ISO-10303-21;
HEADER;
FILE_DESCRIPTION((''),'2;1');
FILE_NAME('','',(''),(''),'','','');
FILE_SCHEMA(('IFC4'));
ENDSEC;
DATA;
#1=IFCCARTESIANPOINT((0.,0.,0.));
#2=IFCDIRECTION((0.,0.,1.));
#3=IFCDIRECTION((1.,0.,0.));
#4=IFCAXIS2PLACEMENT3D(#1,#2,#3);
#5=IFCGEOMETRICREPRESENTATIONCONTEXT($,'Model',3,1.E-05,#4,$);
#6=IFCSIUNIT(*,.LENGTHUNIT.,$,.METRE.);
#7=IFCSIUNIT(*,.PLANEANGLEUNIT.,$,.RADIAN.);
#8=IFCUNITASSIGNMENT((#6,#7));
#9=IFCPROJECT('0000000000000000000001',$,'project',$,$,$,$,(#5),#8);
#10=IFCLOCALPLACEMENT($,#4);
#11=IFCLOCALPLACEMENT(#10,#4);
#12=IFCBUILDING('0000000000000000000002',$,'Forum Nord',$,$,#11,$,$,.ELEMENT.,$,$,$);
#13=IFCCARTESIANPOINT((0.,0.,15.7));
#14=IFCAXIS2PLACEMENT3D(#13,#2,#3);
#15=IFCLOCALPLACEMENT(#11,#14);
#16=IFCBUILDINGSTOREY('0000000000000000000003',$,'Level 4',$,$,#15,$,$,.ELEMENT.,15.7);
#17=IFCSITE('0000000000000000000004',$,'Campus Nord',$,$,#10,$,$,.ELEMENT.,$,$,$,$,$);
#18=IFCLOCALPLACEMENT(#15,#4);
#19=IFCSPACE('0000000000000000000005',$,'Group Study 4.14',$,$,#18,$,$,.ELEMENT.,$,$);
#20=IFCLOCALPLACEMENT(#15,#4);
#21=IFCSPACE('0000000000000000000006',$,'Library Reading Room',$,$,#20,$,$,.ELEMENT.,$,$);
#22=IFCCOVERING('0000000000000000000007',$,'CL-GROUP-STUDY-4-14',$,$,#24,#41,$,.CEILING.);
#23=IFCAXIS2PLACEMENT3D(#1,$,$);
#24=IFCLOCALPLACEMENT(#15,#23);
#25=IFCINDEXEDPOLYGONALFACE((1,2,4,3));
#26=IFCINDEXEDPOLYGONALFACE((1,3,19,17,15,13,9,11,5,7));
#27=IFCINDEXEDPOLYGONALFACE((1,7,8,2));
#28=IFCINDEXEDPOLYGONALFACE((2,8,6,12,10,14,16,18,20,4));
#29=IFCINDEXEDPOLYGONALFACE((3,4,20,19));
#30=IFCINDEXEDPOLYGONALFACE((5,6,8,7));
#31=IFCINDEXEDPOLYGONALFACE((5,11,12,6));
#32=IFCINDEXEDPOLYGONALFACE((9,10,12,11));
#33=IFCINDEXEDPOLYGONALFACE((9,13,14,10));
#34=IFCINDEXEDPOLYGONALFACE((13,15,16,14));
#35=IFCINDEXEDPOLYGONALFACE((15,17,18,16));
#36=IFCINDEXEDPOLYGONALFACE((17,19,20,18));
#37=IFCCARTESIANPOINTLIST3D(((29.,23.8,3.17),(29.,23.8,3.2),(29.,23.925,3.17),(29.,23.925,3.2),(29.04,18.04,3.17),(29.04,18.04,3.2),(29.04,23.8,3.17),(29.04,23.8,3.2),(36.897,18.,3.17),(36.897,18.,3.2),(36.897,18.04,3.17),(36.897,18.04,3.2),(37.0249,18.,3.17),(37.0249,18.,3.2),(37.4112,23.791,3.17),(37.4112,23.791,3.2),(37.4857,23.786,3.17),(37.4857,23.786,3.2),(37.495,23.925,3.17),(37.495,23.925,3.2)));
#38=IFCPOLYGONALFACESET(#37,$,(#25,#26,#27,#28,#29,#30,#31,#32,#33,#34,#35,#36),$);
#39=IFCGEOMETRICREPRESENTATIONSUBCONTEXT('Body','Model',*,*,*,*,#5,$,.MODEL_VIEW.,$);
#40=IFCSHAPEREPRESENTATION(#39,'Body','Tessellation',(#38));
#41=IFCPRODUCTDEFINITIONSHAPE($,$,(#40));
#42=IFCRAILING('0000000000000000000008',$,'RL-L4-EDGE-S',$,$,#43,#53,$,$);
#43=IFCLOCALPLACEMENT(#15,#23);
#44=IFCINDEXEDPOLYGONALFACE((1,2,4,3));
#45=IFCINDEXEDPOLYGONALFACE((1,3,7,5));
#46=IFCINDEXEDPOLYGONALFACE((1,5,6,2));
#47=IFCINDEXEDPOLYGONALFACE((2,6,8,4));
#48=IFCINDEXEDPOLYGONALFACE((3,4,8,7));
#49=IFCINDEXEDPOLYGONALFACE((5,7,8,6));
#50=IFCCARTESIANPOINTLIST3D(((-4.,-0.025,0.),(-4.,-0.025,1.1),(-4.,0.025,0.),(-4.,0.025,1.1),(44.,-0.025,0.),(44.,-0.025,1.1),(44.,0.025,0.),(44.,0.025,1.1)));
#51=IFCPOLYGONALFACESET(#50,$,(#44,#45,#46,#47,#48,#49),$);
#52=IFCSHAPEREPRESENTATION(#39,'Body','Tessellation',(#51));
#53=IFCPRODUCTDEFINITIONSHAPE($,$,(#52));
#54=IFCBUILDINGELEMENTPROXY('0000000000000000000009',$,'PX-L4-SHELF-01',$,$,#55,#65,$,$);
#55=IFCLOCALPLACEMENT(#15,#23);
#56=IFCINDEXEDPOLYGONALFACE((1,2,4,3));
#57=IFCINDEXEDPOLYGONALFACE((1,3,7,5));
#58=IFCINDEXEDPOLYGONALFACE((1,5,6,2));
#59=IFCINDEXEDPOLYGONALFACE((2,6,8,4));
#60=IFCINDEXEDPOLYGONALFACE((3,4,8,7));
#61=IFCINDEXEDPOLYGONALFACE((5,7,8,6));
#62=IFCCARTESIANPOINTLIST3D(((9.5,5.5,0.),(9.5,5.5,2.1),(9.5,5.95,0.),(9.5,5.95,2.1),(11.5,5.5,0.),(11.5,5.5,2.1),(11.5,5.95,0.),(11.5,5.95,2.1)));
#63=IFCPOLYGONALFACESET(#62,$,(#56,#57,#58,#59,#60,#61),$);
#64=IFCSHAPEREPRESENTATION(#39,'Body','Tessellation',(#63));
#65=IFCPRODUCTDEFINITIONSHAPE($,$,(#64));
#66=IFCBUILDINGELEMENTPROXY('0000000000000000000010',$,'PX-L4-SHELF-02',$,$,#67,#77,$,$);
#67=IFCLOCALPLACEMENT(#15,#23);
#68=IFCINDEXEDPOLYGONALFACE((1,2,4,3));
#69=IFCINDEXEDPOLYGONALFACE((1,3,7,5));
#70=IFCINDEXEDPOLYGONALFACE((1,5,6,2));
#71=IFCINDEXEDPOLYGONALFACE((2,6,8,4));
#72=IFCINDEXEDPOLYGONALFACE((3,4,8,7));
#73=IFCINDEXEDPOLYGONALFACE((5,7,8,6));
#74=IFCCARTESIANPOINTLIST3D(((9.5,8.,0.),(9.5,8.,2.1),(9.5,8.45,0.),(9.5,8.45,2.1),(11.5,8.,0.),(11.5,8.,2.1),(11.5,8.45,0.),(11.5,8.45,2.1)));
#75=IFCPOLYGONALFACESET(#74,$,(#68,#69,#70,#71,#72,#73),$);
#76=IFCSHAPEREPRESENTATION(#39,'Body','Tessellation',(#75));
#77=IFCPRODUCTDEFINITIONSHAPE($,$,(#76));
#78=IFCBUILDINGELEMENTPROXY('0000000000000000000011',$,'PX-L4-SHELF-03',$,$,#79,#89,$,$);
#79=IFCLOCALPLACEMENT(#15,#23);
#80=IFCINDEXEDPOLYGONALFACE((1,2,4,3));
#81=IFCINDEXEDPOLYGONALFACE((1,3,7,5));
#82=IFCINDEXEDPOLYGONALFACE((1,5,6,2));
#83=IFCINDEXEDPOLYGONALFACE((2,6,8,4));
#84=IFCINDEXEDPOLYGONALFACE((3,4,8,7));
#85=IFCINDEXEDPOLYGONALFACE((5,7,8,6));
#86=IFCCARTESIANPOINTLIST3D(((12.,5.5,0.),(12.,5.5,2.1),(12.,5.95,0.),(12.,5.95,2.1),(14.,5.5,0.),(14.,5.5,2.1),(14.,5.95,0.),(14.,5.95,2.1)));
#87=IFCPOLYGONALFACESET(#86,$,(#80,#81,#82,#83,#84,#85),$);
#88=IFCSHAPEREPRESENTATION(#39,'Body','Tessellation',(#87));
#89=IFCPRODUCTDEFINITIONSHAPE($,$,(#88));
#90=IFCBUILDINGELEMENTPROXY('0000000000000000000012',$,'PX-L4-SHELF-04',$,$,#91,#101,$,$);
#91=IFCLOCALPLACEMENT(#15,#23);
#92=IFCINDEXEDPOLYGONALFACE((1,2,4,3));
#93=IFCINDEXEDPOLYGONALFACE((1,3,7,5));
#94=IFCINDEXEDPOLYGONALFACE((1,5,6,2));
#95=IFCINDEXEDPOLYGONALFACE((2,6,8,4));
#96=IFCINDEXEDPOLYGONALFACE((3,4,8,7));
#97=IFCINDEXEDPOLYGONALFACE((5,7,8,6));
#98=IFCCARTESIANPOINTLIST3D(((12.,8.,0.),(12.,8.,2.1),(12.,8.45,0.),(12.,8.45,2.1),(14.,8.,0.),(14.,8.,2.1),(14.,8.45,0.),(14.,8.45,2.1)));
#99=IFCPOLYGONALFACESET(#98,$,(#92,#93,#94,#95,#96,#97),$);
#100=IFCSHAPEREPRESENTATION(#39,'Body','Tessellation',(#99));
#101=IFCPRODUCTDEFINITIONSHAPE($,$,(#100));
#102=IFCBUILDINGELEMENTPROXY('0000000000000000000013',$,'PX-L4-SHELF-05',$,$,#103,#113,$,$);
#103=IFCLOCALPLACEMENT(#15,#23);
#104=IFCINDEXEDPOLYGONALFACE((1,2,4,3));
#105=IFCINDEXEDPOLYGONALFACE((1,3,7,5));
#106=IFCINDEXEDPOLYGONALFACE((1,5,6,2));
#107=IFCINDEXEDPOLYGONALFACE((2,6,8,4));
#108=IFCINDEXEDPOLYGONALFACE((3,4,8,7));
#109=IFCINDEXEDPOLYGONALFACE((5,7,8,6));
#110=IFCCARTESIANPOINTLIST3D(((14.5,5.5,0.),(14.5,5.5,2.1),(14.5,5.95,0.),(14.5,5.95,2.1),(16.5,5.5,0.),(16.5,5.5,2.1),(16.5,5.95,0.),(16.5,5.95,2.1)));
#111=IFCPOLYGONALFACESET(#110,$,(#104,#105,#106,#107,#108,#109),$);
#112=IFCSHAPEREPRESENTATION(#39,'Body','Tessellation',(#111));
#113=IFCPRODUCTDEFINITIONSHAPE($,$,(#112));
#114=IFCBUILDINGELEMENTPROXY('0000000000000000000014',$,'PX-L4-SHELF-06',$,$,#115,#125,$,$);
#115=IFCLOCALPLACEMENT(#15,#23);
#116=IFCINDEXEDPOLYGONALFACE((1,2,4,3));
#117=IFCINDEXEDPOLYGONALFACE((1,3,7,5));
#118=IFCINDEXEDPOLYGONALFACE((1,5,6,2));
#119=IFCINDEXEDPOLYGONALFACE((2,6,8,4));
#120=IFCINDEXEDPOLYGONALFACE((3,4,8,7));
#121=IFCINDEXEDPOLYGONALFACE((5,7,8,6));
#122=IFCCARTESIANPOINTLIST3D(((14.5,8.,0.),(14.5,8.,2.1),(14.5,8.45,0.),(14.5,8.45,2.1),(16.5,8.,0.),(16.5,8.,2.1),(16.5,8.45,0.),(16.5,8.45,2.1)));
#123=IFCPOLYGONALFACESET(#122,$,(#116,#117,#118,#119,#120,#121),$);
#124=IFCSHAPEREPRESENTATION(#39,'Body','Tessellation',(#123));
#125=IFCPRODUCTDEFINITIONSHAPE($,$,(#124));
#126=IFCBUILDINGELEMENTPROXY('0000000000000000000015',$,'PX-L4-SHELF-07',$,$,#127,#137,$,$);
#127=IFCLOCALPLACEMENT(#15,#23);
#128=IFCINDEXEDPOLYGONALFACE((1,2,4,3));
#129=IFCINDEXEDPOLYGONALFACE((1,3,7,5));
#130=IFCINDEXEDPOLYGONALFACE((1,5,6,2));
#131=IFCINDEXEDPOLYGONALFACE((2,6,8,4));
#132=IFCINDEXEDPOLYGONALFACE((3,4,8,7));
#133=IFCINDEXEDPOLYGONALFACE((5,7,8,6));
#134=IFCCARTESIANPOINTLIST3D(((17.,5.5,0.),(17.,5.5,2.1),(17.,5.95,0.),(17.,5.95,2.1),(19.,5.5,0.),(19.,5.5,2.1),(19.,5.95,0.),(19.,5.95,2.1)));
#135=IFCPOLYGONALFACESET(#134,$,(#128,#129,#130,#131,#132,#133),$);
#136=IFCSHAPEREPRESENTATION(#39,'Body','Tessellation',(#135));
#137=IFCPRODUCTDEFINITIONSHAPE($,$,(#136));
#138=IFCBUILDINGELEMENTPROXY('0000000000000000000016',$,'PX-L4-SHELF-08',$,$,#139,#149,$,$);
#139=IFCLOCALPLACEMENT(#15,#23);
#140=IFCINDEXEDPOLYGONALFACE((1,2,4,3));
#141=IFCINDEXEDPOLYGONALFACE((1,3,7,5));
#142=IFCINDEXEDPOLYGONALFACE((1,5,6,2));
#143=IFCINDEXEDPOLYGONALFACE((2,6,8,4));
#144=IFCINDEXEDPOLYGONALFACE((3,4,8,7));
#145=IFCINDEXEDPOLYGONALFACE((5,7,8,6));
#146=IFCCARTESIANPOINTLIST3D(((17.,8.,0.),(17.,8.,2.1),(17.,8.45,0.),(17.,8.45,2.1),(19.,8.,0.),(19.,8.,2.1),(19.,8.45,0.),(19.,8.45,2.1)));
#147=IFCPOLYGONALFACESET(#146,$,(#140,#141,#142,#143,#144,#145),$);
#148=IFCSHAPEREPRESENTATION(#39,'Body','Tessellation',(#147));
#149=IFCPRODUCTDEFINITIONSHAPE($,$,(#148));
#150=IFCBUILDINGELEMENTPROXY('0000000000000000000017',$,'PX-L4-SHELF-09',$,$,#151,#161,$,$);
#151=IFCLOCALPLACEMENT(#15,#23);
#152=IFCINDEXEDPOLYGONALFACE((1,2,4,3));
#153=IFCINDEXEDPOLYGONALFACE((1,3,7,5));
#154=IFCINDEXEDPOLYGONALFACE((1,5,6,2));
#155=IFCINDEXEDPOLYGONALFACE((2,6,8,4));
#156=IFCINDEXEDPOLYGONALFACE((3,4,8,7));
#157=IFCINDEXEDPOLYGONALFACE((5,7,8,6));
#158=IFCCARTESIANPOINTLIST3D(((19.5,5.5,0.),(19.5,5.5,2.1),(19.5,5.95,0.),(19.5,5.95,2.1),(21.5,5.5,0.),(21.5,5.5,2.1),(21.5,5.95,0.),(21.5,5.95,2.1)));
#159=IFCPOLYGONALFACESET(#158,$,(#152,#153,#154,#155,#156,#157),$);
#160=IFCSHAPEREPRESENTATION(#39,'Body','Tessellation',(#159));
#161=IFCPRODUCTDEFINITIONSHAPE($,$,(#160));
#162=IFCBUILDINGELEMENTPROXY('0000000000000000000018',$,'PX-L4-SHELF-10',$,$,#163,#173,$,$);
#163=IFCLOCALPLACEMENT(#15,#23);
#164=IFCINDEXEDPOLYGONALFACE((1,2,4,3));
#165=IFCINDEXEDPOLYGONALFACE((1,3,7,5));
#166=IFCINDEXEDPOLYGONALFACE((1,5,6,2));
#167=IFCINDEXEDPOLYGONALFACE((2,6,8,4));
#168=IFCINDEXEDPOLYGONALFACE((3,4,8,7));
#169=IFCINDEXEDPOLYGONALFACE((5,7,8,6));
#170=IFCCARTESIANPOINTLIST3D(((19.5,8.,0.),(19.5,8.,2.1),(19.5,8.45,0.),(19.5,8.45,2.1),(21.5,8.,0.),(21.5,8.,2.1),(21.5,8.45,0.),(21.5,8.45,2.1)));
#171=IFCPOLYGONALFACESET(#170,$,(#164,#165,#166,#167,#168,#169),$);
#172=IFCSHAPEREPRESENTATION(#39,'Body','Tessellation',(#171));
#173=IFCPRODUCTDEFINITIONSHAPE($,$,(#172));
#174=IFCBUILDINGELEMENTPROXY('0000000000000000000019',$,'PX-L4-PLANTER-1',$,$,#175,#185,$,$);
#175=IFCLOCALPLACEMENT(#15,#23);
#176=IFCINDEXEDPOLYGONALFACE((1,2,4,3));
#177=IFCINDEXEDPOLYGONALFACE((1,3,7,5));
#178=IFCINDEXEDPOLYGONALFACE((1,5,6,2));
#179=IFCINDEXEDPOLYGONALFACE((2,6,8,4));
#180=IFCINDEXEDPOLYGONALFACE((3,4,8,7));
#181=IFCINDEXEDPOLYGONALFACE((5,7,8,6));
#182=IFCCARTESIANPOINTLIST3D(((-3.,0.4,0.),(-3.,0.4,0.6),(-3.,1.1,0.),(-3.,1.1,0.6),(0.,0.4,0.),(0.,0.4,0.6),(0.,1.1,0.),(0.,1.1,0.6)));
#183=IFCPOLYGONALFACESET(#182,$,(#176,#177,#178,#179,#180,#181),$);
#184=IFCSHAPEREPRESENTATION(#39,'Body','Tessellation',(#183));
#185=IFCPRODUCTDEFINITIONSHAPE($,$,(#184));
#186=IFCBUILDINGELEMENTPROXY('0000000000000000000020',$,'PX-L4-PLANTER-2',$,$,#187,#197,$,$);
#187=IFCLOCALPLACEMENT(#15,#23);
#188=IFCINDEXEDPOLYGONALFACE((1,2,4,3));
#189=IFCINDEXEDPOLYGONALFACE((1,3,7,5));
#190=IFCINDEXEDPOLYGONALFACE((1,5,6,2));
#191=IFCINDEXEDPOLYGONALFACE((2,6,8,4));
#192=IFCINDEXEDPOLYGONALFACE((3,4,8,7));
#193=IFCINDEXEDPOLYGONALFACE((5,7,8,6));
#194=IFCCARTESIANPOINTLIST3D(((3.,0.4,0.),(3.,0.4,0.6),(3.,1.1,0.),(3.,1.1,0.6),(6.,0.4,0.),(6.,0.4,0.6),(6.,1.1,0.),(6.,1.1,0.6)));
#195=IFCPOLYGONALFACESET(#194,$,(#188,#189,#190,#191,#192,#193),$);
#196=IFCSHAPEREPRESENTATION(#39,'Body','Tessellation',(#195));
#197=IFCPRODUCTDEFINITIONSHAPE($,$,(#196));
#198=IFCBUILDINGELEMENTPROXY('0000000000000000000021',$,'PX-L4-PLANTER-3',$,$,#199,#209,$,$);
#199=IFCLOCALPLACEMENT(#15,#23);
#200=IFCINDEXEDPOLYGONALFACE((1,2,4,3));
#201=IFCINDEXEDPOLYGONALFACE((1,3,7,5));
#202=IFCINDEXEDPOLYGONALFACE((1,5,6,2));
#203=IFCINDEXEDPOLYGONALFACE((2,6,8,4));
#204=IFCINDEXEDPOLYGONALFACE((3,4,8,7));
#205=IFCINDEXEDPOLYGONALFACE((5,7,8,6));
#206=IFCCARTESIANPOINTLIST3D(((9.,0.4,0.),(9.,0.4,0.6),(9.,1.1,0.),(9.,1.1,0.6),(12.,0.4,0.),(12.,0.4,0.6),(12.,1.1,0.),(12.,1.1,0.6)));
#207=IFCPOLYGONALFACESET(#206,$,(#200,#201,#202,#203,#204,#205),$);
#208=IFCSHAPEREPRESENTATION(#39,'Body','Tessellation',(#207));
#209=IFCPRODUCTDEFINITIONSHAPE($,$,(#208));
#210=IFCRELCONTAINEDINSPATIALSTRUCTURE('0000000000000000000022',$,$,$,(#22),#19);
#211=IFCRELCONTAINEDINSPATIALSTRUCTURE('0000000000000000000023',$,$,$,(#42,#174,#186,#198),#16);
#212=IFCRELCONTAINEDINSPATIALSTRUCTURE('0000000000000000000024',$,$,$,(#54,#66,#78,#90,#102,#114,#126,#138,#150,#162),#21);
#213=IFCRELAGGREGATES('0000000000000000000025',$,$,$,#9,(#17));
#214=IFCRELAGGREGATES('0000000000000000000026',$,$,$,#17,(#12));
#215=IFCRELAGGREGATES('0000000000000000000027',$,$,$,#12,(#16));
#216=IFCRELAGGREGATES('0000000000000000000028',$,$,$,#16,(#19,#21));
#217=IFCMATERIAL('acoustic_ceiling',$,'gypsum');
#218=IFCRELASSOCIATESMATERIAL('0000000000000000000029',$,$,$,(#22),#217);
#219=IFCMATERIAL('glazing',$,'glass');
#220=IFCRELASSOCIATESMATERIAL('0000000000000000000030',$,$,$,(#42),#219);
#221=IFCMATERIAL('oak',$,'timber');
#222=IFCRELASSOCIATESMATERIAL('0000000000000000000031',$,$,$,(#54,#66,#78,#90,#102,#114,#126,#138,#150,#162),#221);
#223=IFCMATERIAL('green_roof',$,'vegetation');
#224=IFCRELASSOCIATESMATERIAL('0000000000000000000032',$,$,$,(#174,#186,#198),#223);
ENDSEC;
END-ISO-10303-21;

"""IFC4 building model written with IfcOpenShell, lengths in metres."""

from ifc_helpers import new_model, si_unit, frame, frame_2d, origin_with_axes, place, context, subcontext, project, spatial, polyline, rectangle, outline, extrude, material, element, save


model = new_model("IFC4")

# Units and contexts
model_context = context("Model", 3, precision=1e-05, world=origin_with_axes())
body_context = subcontext(model_context, "Body", "Model", "MODEL_VIEW")
ifc_project = project(units=[si_unit("LENGTHUNIT", "METRE"), si_unit("PLANEANGLEUNIT", "RADIAN")], contexts=[model_context])

# Site, building, storey
site_placement = place(None, origin_with_axes())
site = spatial("IfcSite", under=ifc_project, at=site_placement, Name="Campus Nord", CompositionType="ELEMENT")
building_placement = place(site_placement, origin_with_axes())
building = spatial("IfcBuilding", under=site, at=building_placement, Name="Forum Nord", CompositionType="ELEMENT")
storey_placement = place(building_placement, frame((0.0, 0.0, 15.7), z_axis=(0.0, 0.0, 1.0), x_axis=(1.0, 0.0, 0.0)))
storey = spatial("IfcBuildingStorey", under=building, at=storey_placement, Name="Level 4", CompositionType="ELEMENT", Elevation=15.7)

# Shared definitions
ifc_material_1 = material(Name="acoustic_ceiling", Category="gypsum")

# Shared definitions
space_1_placement = place(storey_placement, origin_with_axes())
space_1 = spatial("IfcSpace", under=storey, at=space_1_placement, Name="Group Study 4.14", CompositionType="ELEMENT")

# Covering
covering_1_placement = place(storey_placement, frame((0.0, 0.0, 3.17), z_axis=(0.0, 0.0, 1.0), x_axis=(1.0, 0.0, 0.0)))
element("IfcCovering", 1, at=covering_1_placement, inside=space_1, material=ifc_material_1, Name="CL-GROUP-STUDY-4-14", PredefinedType="CEILING", context=body_context, shape_type="SweptSolid", body=[
    extrude(outline(polyline([(29.0, 23.925), (29.0, 23.8), (29.04, 23.8), (29.04, 18.04), (36.897, 18.04), (36.897, 18.0), (37.0249, 18.0), (37.4112, 23.791), (37.4857, 23.786), (37.495, 23.925), (29.0, 23.925)])), origin_with_axes(), (0.0, 0.0, 1.0), 0.03),
])

# Railing
ifc_material_2 = material(Name="glazing", Category="glass")
railing_placement = place(storey_placement, frame((-4.0, 0.0, 0.0), z_axis=(0.0, 0.0, 1.0), x_axis=(1.0, 0.0, 0.0)))
element("IfcRailing", 2, at=railing_placement, inside=storey, material=ifc_material_2, Name="RL-L4-EDGE-S", context=body_context, shape_type="SweptSolid", body=[
    extrude(rectangle(XDim=48.0, YDim=0.05, at=frame_2d((24.0, 0.0), x_axis=(1.0, 0.0))), origin_with_axes(), (0.0, 0.0, 1.0), 1.1),
])

# Shared definitions
space_2_placement = place(storey_placement, origin_with_axes())
space_2 = spatial("IfcSpace", under=storey, at=space_2_placement, Name="Library Reading Room", CompositionType="ELEMENT")

# Building element proxies
ifc_material_3 = material(Name="oak", Category="timber")
proxy_1_placement = place(storey_placement, origin_with_axes())
element("IfcBuildingElementProxy", 3, at=proxy_1_placement, inside=space_2, material=ifc_material_3, Name="PX-L4-SHELF-01", context=body_context, shape_type="SweptSolid", body=[
    extrude(outline(polyline([(9.5, 5.5), (11.5, 5.5), (11.5, 5.95), (9.5, 5.95), (9.5, 5.5)])), origin_with_axes(), (0.0, 0.0, 1.0), 2.1),
])
proxy_2_placement = place(storey_placement, origin_with_axes())
element("IfcBuildingElementProxy", 4, at=proxy_2_placement, inside=space_2, material=ifc_material_3, Name="PX-L4-SHELF-02", context=body_context, shape_type="SweptSolid", body=[
    extrude(outline(polyline([(9.5, 8.0), (11.5, 8.0), (11.5, 8.45), (9.5, 8.45), (9.5, 8.0)])), origin_with_axes(), (0.0, 0.0, 1.0), 2.1),
])
proxy_3_placement = place(storey_placement, origin_with_axes())
element("IfcBuildingElementProxy", 5, at=proxy_3_placement, inside=space_2, material=ifc_material_3, Name="PX-L4-SHELF-03", context=body_context, shape_type="SweptSolid", body=[
    extrude(outline(polyline([(12.0, 5.5), (14.0, 5.5), (14.0, 5.95), (12.0, 5.95), (12.0, 5.5)])), origin_with_axes(), (0.0, 0.0, 1.0), 2.1),
])
proxy_4_placement = place(storey_placement, origin_with_axes())
element("IfcBuildingElementProxy", 6, at=proxy_4_placement, inside=space_2, material=ifc_material_3, Name="PX-L4-SHELF-04", context=body_context, shape_type="SweptSolid", body=[
    extrude(outline(polyline([(12.0, 8.0), (14.0, 8.0), (14.0, 8.45), (12.0, 8.45), (12.0, 8.0)])), origin_with_axes(), (0.0, 0.0, 1.0), 2.1),
])
proxy_5_placement = place(storey_placement, origin_with_axes())
element("IfcBuildingElementProxy", 7, at=proxy_5_placement, inside=space_2, material=ifc_material_3, Name="PX-L4-SHELF-05", context=body_context, shape_type="SweptSolid", body=[
    extrude(outline(polyline([(14.5, 5.5), (16.5, 5.5), (16.5, 5.95), (14.5, 5.95), (14.5, 5.5)])), origin_with_axes(), (0.0, 0.0, 1.0), 2.1),
])
proxy_6_placement = place(storey_placement, origin_with_axes())
element("IfcBuildingElementProxy", 8, at=proxy_6_placement, inside=space_2, material=ifc_material_3, Name="PX-L4-SHELF-06", context=body_context, shape_type="SweptSolid", body=[
    extrude(outline(polyline([(14.5, 8.0), (16.5, 8.0), (16.5, 8.45), (14.5, 8.45), (14.5, 8.0)])), origin_with_axes(), (0.0, 0.0, 1.0), 2.1),
])
proxy_7_placement = place(storey_placement, origin_with_axes())
element("IfcBuildingElementProxy", 9, at=proxy_7_placement, inside=space_2, material=ifc_material_3, Name="PX-L4-SHELF-07", context=body_context, shape_type="SweptSolid", body=[
    extrude(outline(polyline([(17.0, 5.5), (19.0, 5.5), (19.0, 5.95), (17.0, 5.95), (17.0, 5.5)])), origin_with_axes(), (0.0, 0.0, 1.0), 2.1),
])
proxy_8_placement = place(storey_placement, origin_with_axes())
element("IfcBuildingElementProxy", 10, at=proxy_8_placement, inside=space_2, material=ifc_material_3, Name="PX-L4-SHELF-08", context=body_context, shape_type="SweptSolid", body=[
    extrude(outline(polyline([(17.0, 8.0), (19.0, 8.0), (19.0, 8.45), (17.0, 8.45), (17.0, 8.0)])), origin_with_axes(), (0.0, 0.0, 1.0), 2.1),
])
proxy_9_placement = place(storey_placement, origin_with_axes())
element("IfcBuildingElementProxy", 11, at=proxy_9_placement, inside=space_2, material=ifc_material_3, Name="PX-L4-SHELF-09", context=body_context, shape_type="SweptSolid", body=[
    extrude(outline(polyline([(19.5, 5.5), (21.5, 5.5), (21.5, 5.95), (19.5, 5.95), (19.5, 5.5)])), origin_with_axes(), (0.0, 0.0, 1.0), 2.1),
])
proxy_10_placement = place(storey_placement, origin_with_axes())
element("IfcBuildingElementProxy", 12, at=proxy_10_placement, inside=space_2, material=ifc_material_3, Name="PX-L4-SHELF-10", context=body_context, shape_type="SweptSolid", body=[
    extrude(outline(polyline([(19.5, 8.0), (21.5, 8.0), (21.5, 8.45), (19.5, 8.45), (19.5, 8.0)])), origin_with_axes(), (0.0, 0.0, 1.0), 2.1),
])
ifc_material_4 = material(Name="green_roof", Category="vegetation")
proxy_11_placement = place(storey_placement, origin_with_axes())
element("IfcBuildingElementProxy", 13, at=proxy_11_placement, inside=storey, material=ifc_material_4, Name="PX-L4-PLANTER-1", context=body_context, shape_type="SweptSolid", body=[
    extrude(outline(polyline([(-3.0, 0.4), (0.0, 0.4), (0.0, 1.1), (-3.0, 1.1), (-3.0, 0.4)])), origin_with_axes(), (0.0, 0.0, 1.0), 0.6),
])
proxy_12_placement = place(storey_placement, origin_with_axes())
element("IfcBuildingElementProxy", 14, at=proxy_12_placement, inside=storey, material=ifc_material_4, Name="PX-L4-PLANTER-2", context=body_context, shape_type="SweptSolid", body=[
    extrude(outline(polyline([(3.0, 0.4), (6.0, 0.4), (6.0, 1.1), (3.0, 1.1), (3.0, 0.4)])), origin_with_axes(), (0.0, 0.0, 1.0), 0.6),
])
proxy_13_placement = place(storey_placement, origin_with_axes())
element("IfcBuildingElementProxy", 15, at=proxy_13_placement, inside=storey, material=ifc_material_4, Name="PX-L4-PLANTER-3", context=body_context, shape_type="SweptSolid", body=[
    extrude(outline(polyline([(9.0, 0.4), (12.0, 0.4), (12.0, 1.1), (9.0, 1.1), (9.0, 0.4)])), origin_with_axes(), (0.0, 0.0, 1.0), 0.6),
])

save(model, "model.ifc")
